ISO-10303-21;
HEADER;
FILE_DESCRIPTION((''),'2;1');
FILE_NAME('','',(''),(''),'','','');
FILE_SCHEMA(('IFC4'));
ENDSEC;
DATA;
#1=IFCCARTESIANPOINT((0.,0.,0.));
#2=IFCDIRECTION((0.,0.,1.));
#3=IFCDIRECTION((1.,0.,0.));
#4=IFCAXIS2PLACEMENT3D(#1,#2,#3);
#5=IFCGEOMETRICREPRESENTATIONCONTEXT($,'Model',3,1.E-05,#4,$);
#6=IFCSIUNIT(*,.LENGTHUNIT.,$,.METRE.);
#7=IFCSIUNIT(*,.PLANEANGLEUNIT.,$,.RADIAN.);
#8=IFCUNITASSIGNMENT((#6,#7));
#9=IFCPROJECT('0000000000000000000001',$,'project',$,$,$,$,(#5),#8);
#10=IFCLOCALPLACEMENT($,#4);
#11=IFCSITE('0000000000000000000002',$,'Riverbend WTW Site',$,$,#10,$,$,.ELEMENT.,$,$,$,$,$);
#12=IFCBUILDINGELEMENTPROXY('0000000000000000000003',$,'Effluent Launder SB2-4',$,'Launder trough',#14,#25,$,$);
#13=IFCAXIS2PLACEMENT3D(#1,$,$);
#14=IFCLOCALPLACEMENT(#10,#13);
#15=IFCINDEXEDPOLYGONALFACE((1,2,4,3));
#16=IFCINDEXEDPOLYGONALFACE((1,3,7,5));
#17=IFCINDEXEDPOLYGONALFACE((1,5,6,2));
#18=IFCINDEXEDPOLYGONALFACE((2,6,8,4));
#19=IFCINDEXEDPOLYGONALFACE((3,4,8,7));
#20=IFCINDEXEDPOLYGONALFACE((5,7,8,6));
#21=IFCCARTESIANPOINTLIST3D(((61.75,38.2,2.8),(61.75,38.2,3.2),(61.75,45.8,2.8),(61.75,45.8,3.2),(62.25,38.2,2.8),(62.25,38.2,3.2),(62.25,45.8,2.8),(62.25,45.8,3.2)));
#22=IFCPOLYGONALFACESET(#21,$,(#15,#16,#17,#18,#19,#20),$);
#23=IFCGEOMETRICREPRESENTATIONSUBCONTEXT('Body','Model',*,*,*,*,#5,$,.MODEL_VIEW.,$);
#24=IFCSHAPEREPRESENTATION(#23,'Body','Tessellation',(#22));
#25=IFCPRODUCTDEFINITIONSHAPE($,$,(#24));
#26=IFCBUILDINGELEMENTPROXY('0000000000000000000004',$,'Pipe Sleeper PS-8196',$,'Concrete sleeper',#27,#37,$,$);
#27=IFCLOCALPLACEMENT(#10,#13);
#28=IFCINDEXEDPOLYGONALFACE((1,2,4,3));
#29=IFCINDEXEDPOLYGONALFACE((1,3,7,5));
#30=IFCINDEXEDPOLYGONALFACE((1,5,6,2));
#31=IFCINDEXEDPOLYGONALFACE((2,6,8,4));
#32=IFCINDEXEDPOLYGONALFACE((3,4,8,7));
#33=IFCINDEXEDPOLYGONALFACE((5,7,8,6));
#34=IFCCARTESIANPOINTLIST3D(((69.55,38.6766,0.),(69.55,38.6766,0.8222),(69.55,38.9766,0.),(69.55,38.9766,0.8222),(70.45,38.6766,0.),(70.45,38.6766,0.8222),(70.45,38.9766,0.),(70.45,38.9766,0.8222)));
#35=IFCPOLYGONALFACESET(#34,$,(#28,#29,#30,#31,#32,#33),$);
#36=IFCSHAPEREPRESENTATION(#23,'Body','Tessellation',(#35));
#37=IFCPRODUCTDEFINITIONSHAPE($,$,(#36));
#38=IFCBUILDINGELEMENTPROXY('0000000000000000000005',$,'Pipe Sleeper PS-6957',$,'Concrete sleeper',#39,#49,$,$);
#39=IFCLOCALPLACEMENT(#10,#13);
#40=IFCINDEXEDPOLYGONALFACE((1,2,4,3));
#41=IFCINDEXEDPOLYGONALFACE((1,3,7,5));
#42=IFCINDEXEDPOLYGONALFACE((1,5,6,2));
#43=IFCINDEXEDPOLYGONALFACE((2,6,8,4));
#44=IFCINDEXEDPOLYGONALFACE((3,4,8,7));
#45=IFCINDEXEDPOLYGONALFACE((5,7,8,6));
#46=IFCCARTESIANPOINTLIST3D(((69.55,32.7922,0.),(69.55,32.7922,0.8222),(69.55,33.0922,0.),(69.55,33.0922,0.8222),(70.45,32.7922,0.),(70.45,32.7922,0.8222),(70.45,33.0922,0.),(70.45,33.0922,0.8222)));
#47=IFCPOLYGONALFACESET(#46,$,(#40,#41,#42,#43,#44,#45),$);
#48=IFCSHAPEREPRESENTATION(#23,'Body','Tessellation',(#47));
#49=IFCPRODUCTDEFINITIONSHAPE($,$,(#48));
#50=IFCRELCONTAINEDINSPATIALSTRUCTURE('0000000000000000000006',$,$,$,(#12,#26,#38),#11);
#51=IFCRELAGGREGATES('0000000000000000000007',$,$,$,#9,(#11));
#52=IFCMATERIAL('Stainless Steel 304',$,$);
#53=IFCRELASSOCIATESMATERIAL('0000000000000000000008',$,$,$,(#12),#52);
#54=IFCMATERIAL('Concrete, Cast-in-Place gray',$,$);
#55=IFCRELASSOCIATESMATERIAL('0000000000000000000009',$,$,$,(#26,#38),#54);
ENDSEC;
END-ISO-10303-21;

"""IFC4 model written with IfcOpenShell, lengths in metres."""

from ifc_helpers import new_model, si_unit, frame, origin_with_axes, origin_2d, place, context, subcontext, project, spatial, rectangle, extrude, material, element, save


model = new_model("IFC4")

# Units and contexts
model_context = context("Model", 3, precision=1e-05, world=origin_with_axes())
body_context = subcontext(model_context, "Body", "Model", "MODEL_VIEW")
ifc_project = project(units=[si_unit("LENGTHUNIT", "METRE"), si_unit("PLANEANGLEUNIT", "RADIAN")], contexts=[model_context])

# Site
site_placement = place(None, origin_with_axes())
site = spatial("IfcSite", under=ifc_project, at=site_placement, Name="Riverbend WTW Site", CompositionType="ELEMENT")

# Shared definitions
ifc_material_1 = material(Name="Concrete, Cast-in-Place gray")

# Building element proxies
ifc_material_2 = material(Name="Stainless Steel 304")
proxy_1_placement = place(None, frame((62.0, 42.0, 3.0), z_axis=(0.0, 0.0, 1.0), x_axis=(1.0, 0.0, 0.0)))
element("IfcBuildingElementProxy", 1, at=proxy_1_placement, inside=site, material=ifc_material_2, Name="Effluent Launder SB2-4", ObjectType="Launder trough", context=body_context, shape_type="SweptSolid", body=[
    extrude(rectangle(XDim=0.5, YDim=7.6, at=origin_2d()), frame((0.0, 0.0, -0.2), z_axis=(0.0, 0.0, 1.0), x_axis=(1.0, 0.0, 0.0)), (0.0, 0.0, 1.0), 0.4),
])
for number, where, z_axis, x_axis, name in (
    (2, (70.0, 38.8266, 0.4111), (0.0, 0.0, 1.0), (1.0, 0.0, 0.0), "Pipe Sleeper PS-8196"),
    (3, (70.0, 32.9422, 0.4111), (0.0, 0.0, 1.0), (1.0, 0.0, 0.0), "Pipe Sleeper PS-6957"),
):
    element("IfcBuildingElementProxy", number, at=place(None, frame(where, z_axis=z_axis, x_axis=x_axis)), inside=site, material=ifc_material_1, Name=name, ObjectType="Concrete sleeper", context=body_context, shape_type="SweptSolid", body=[
        extrude(rectangle(XDim=0.9, YDim=0.3, at=origin_2d()), frame((0.0, 0.0, -0.4111), z_axis=(0.0, 0.0, 1.0), x_axis=(1.0, 0.0, 0.0)), (0.0, 0.0, 1.0), 0.8222),
    ])

save(model, "model.ifc")
